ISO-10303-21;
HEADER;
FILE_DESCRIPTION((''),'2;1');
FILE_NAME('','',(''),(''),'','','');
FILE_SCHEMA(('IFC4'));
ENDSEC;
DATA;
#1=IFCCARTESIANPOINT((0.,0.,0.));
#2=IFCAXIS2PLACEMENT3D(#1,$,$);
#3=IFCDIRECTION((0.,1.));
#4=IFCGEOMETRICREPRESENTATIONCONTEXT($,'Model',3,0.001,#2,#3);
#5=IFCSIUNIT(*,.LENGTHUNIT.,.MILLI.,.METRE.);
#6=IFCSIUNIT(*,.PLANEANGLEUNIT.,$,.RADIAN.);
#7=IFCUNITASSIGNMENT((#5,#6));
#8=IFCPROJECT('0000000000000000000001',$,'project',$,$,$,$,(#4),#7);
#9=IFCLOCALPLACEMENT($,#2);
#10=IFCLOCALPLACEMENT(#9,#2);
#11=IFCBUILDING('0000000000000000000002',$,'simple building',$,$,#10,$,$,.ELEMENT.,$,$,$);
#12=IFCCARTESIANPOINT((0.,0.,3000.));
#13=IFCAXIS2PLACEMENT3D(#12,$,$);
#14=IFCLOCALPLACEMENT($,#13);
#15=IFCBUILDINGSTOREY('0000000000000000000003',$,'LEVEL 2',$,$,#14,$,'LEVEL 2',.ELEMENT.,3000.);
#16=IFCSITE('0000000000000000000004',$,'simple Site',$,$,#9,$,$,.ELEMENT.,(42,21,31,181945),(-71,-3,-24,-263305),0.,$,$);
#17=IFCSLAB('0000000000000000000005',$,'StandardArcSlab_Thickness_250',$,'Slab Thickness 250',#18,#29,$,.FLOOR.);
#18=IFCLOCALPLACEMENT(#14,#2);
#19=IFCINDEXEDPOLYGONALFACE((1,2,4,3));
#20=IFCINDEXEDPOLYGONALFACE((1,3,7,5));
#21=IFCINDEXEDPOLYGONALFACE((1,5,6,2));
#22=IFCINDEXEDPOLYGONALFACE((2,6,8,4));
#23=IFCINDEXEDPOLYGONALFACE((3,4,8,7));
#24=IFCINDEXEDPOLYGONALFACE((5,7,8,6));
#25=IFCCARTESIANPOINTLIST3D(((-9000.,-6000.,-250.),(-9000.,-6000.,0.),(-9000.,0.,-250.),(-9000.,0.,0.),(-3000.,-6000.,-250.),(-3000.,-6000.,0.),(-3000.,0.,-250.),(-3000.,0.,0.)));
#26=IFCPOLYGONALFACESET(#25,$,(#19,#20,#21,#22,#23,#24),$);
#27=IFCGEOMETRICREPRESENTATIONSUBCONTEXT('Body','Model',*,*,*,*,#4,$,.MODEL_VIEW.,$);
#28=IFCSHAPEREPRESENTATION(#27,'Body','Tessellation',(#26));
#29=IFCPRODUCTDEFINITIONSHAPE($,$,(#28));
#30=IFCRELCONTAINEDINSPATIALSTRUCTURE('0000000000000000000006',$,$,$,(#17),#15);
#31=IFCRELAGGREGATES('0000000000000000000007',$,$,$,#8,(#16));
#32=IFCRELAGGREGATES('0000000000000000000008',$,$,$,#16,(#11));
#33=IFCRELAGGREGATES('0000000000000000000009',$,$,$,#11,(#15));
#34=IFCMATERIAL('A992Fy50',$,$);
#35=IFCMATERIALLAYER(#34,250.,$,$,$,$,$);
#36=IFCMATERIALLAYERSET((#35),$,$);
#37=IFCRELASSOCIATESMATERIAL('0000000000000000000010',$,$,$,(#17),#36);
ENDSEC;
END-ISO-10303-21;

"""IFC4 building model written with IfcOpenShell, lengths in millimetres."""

from ifc_helpers import new_model, si_unit, direction, frame, origin, origin_with_axes, place, context, subcontext, project, spatial, polyline, outline, extrude, material, layer, layer_set, layer_usage, element, save


model = new_model("IFC4")

# Units and contexts
model_context = context("Model", 3, precision=0.001, world=origin(), true_north=direction((0.0, 1.0)))
body_context = subcontext(model_context, "Body", "Model", "MODEL_VIEW")
ifc_project = project(units=[si_unit("LENGTHUNIT", "METRE", prefix="MILLI"), si_unit("PLANEANGLEUNIT", "RADIAN")], contexts=[model_context])

# Site, building, storey
site_placement = place(None, origin())
site = spatial("IfcSite", under=ifc_project, at=site_placement, Name="simple Site", CompositionType="ELEMENT", RefLatitude=(42, 21, 31, 181945), RefLongitude=(-71, -3, -24, -263305), RefElevation=0.0)
building_placement = place(site_placement, origin())
building = spatial("IfcBuilding", under=site, at=building_placement, Name="simple building", CompositionType="ELEMENT")
storey_placement = place(None, frame((0.0, 0.0, 3000.0)))
storey = spatial("IfcBuildingStorey", under=building, at=storey_placement, Name="LEVEL 2", LongName="LEVEL 2", CompositionType="ELEMENT", Elevation=3000.0)

# Slab
ifc_material_1 = material(Name="A992Fy50")
ifc_layer = layer(ifc_material_1, 250.0)
ifc_layer_set = layer_set([ifc_layer])
ifc_layer_usage = layer_usage(ifc_layer_set, "AXIS3", "POSITIVE", -250.0)
slab_1_placement = place(None, frame((-9000.0, 0.0, 2750.0), z_axis=(0.0, 0.0, 1.0), x_axis=(0.0, -1.0, 0.0)))
element("IfcSlab", 1, at=slab_1_placement, inside=storey, material=ifc_layer_usage, Name="StandardArcSlab_Thickness_250", ObjectType="Slab Thickness 250", PredefinedType="FLOOR", context=body_context, shape_type="SweptSolid", body=[
    extrude(outline(polyline([(0.0, 0.0), (6000.0, 0.0), (6000.0, 6000.0), (0.0, 6000.0), (0.0, 0.0)])), origin_with_axes(), (0.0, 0.0, 1.0), 250.0),
])

save(model, "model.ifc")
